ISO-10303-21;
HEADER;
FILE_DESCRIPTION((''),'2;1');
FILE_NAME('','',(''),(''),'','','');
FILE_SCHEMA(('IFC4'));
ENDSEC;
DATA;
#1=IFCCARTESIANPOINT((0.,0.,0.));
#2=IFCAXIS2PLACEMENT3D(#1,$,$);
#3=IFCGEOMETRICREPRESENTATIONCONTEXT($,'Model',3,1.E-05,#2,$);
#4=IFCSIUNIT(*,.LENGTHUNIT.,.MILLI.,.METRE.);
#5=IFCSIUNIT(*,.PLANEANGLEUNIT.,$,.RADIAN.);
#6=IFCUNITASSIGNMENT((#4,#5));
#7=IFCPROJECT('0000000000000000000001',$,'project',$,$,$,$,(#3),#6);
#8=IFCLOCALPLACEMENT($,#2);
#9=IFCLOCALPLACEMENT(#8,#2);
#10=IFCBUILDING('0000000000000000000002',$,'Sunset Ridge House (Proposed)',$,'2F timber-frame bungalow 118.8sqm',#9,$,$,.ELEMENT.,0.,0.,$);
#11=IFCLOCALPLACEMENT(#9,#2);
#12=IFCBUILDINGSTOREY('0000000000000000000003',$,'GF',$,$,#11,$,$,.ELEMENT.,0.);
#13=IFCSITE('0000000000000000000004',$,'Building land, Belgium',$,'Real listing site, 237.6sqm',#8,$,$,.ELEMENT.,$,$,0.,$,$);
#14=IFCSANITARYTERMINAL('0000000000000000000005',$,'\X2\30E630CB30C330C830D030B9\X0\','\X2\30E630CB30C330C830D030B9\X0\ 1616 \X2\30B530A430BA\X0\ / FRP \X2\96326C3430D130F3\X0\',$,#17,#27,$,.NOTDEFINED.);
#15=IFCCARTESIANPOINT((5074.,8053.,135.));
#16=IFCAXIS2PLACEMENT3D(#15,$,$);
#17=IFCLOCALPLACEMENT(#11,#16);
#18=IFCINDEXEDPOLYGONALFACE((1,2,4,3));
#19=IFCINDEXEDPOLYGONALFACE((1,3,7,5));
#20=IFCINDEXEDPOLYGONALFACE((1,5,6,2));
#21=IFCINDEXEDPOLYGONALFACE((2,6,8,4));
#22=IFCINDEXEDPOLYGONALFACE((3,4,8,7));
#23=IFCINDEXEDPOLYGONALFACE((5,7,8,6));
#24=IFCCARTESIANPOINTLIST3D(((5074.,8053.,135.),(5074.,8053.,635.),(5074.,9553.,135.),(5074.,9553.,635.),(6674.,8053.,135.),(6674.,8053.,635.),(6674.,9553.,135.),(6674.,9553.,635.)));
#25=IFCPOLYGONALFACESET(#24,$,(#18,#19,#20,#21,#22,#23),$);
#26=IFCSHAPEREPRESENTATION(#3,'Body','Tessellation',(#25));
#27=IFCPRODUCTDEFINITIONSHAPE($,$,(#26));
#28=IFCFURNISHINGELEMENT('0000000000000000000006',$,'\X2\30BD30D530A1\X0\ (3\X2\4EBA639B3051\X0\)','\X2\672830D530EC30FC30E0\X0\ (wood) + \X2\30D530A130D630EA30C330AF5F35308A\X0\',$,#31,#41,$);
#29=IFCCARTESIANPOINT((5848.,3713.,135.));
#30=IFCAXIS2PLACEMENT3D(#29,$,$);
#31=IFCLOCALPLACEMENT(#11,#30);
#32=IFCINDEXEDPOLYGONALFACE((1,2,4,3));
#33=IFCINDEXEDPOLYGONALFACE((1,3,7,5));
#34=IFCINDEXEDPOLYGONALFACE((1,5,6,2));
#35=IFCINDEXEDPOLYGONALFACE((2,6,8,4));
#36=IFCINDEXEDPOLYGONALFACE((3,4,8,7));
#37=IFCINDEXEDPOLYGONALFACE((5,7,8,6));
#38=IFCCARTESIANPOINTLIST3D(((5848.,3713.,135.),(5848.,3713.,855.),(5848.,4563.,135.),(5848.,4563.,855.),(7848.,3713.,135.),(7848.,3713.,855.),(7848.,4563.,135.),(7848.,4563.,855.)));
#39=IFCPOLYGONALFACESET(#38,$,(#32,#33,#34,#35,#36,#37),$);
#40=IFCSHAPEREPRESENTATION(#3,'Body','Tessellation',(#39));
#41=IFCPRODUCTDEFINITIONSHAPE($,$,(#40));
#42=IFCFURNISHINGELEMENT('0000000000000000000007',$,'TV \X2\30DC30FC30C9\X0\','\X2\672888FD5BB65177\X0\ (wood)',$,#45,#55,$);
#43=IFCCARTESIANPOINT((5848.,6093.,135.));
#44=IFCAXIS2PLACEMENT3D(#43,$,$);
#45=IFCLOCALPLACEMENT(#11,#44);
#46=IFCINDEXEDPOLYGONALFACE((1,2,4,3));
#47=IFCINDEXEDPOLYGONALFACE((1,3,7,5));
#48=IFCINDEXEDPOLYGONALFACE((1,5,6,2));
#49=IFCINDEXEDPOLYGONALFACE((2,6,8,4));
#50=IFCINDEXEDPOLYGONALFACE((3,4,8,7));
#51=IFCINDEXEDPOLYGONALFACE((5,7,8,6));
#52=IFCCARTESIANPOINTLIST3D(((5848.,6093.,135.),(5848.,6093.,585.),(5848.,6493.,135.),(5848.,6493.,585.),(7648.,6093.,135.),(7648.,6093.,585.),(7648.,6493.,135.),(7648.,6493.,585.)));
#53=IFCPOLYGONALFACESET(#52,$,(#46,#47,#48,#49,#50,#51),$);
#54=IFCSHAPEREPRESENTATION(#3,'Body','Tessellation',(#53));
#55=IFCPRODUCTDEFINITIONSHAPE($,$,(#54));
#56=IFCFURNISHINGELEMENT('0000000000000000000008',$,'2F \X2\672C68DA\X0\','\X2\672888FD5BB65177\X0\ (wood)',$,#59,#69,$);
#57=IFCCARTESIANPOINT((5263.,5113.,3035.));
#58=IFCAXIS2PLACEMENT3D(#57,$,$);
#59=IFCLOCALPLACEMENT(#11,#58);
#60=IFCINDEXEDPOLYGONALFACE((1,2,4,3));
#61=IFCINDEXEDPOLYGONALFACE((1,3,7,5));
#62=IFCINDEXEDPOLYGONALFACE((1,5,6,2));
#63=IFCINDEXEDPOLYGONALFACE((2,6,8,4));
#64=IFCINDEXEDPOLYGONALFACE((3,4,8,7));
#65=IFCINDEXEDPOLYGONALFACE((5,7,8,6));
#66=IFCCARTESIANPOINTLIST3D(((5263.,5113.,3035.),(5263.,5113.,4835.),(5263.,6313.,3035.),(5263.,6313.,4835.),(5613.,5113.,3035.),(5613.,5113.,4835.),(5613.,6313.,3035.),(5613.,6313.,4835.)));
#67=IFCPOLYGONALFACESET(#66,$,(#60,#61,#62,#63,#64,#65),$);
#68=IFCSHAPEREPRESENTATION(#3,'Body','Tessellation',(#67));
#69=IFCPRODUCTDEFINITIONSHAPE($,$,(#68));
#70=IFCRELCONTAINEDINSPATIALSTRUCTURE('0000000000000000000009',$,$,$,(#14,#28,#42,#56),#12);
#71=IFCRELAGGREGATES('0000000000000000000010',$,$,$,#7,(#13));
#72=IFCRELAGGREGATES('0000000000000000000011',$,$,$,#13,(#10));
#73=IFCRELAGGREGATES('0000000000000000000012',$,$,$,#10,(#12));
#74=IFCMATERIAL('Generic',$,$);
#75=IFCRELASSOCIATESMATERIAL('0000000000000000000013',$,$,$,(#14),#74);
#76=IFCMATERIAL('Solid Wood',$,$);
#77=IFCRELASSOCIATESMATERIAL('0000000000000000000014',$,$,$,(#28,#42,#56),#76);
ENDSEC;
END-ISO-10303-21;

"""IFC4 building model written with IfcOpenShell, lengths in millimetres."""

from ifc_helpers import new_model, si_unit, frame, frame_2d, origin, place, context, project, spatial, rectangle, extrude, material, element, save


model = new_model("IFC4")

# Units and contexts
model_context = context("Model", 3, precision=1e-05, world=origin())
ifc_project = project(units=[si_unit("LENGTHUNIT", "METRE", prefix="MILLI"), si_unit("PLANEANGLEUNIT", "RADIAN")], contexts=[model_context])

# Site, building, storey
site_placement = place(None, origin())
site = spatial("IfcSite", under=ifc_project, at=site_placement, Name="Building land, Belgium", ObjectType="Real listing site, 237.6sqm", CompositionType="ELEMENT", RefElevation=0.0)
building_placement = place(site_placement, origin())
building = spatial("IfcBuilding", under=site, at=building_placement, Name="Sunset Ridge House (Proposed)", ObjectType="2F timber-frame bungalow 118.8sqm", CompositionType="ELEMENT", ElevationOfRefHeight=0.0, ElevationOfTerrain=0.0)
storey_placement = place(building_placement, origin())
storey = spatial("IfcBuildingStorey", under=building, at=storey_placement, Name="GF", CompositionType="ELEMENT", Elevation=0.0)

# Shared definitions
ifc_material_1 = material(Name="Solid Wood")

# Sanitary terminal
ifc_material_2 = material(Name="Generic")
sanitary_terminal_placement = place(storey_placement, frame((5074.0, 8053.0, 135.0)))
element("IfcSanitaryTerminal", 1, at=sanitary_terminal_placement, inside=storey, material=ifc_material_2, Name="ユニットバス", Description="ユニットバス 1616 サイズ / FRP 防水パン", PredefinedType="NOTDEFINED", context=model_context, shape_type="SweptSolid", body=[
    extrude(rectangle(XDim=1600.0, YDim=1500.0, at=frame_2d((800.0, 750.0))), frame((5074.0, 8053.0, 135.0)), (0.0, 0.0, 1.0), 500.0),
])

# Furnishing elements
furnishing_1_placement = place(storey_placement, frame((5848.0, 3713.0, 135.0)))
element("IfcFurnishingElement", 2, at=furnishing_1_placement, inside=storey, material=ifc_material_1, Name="ソファ (3人掛け)", Description="木フレーム (wood) + ファブリック張り", context=model_context, shape_type="SweptSolid", body=[
    extrude(rectangle(XDim=2000.0, YDim=850.0, at=frame_2d((1000.0, 425.0))), frame((5848.0, 3713.0, 135.0)), (0.0, 0.0, 1.0), 720.0),
])
furnishing_2_placement = place(storey_placement, frame((5848.0, 6093.0, 135.0)))
element("IfcFurnishingElement", 3, at=furnishing_2_placement, inside=storey, material=ifc_material_1, Name="TV ボード", Description="木製家具 (wood)", context=model_context, shape_type="SweptSolid", body=[
    extrude(rectangle(XDim=1800.0, YDim=400.0, at=frame_2d((900.0, 200.0))), frame((5848.0, 6093.0, 135.0)), (0.0, 0.0, 1.0), 450.0),
])
furnishing_3_placement = place(storey_placement, frame((5263.0, 5113.0, 3035.0)))
element("IfcFurnishingElement", 4, at=furnishing_3_placement, inside=storey, material=ifc_material_1, Name="2F 本棚", Description="木製家具 (wood)", context=model_context, shape_type="SweptSolid", body=[
    extrude(rectangle(XDim=350.0, YDim=1200.0, at=frame_2d((175.0, 600.0))), frame((5263.0, 5113.0, 3035.0)), (0.0, 0.0, 1.0), 1800.0),
])

save(model, "model.ifc")
